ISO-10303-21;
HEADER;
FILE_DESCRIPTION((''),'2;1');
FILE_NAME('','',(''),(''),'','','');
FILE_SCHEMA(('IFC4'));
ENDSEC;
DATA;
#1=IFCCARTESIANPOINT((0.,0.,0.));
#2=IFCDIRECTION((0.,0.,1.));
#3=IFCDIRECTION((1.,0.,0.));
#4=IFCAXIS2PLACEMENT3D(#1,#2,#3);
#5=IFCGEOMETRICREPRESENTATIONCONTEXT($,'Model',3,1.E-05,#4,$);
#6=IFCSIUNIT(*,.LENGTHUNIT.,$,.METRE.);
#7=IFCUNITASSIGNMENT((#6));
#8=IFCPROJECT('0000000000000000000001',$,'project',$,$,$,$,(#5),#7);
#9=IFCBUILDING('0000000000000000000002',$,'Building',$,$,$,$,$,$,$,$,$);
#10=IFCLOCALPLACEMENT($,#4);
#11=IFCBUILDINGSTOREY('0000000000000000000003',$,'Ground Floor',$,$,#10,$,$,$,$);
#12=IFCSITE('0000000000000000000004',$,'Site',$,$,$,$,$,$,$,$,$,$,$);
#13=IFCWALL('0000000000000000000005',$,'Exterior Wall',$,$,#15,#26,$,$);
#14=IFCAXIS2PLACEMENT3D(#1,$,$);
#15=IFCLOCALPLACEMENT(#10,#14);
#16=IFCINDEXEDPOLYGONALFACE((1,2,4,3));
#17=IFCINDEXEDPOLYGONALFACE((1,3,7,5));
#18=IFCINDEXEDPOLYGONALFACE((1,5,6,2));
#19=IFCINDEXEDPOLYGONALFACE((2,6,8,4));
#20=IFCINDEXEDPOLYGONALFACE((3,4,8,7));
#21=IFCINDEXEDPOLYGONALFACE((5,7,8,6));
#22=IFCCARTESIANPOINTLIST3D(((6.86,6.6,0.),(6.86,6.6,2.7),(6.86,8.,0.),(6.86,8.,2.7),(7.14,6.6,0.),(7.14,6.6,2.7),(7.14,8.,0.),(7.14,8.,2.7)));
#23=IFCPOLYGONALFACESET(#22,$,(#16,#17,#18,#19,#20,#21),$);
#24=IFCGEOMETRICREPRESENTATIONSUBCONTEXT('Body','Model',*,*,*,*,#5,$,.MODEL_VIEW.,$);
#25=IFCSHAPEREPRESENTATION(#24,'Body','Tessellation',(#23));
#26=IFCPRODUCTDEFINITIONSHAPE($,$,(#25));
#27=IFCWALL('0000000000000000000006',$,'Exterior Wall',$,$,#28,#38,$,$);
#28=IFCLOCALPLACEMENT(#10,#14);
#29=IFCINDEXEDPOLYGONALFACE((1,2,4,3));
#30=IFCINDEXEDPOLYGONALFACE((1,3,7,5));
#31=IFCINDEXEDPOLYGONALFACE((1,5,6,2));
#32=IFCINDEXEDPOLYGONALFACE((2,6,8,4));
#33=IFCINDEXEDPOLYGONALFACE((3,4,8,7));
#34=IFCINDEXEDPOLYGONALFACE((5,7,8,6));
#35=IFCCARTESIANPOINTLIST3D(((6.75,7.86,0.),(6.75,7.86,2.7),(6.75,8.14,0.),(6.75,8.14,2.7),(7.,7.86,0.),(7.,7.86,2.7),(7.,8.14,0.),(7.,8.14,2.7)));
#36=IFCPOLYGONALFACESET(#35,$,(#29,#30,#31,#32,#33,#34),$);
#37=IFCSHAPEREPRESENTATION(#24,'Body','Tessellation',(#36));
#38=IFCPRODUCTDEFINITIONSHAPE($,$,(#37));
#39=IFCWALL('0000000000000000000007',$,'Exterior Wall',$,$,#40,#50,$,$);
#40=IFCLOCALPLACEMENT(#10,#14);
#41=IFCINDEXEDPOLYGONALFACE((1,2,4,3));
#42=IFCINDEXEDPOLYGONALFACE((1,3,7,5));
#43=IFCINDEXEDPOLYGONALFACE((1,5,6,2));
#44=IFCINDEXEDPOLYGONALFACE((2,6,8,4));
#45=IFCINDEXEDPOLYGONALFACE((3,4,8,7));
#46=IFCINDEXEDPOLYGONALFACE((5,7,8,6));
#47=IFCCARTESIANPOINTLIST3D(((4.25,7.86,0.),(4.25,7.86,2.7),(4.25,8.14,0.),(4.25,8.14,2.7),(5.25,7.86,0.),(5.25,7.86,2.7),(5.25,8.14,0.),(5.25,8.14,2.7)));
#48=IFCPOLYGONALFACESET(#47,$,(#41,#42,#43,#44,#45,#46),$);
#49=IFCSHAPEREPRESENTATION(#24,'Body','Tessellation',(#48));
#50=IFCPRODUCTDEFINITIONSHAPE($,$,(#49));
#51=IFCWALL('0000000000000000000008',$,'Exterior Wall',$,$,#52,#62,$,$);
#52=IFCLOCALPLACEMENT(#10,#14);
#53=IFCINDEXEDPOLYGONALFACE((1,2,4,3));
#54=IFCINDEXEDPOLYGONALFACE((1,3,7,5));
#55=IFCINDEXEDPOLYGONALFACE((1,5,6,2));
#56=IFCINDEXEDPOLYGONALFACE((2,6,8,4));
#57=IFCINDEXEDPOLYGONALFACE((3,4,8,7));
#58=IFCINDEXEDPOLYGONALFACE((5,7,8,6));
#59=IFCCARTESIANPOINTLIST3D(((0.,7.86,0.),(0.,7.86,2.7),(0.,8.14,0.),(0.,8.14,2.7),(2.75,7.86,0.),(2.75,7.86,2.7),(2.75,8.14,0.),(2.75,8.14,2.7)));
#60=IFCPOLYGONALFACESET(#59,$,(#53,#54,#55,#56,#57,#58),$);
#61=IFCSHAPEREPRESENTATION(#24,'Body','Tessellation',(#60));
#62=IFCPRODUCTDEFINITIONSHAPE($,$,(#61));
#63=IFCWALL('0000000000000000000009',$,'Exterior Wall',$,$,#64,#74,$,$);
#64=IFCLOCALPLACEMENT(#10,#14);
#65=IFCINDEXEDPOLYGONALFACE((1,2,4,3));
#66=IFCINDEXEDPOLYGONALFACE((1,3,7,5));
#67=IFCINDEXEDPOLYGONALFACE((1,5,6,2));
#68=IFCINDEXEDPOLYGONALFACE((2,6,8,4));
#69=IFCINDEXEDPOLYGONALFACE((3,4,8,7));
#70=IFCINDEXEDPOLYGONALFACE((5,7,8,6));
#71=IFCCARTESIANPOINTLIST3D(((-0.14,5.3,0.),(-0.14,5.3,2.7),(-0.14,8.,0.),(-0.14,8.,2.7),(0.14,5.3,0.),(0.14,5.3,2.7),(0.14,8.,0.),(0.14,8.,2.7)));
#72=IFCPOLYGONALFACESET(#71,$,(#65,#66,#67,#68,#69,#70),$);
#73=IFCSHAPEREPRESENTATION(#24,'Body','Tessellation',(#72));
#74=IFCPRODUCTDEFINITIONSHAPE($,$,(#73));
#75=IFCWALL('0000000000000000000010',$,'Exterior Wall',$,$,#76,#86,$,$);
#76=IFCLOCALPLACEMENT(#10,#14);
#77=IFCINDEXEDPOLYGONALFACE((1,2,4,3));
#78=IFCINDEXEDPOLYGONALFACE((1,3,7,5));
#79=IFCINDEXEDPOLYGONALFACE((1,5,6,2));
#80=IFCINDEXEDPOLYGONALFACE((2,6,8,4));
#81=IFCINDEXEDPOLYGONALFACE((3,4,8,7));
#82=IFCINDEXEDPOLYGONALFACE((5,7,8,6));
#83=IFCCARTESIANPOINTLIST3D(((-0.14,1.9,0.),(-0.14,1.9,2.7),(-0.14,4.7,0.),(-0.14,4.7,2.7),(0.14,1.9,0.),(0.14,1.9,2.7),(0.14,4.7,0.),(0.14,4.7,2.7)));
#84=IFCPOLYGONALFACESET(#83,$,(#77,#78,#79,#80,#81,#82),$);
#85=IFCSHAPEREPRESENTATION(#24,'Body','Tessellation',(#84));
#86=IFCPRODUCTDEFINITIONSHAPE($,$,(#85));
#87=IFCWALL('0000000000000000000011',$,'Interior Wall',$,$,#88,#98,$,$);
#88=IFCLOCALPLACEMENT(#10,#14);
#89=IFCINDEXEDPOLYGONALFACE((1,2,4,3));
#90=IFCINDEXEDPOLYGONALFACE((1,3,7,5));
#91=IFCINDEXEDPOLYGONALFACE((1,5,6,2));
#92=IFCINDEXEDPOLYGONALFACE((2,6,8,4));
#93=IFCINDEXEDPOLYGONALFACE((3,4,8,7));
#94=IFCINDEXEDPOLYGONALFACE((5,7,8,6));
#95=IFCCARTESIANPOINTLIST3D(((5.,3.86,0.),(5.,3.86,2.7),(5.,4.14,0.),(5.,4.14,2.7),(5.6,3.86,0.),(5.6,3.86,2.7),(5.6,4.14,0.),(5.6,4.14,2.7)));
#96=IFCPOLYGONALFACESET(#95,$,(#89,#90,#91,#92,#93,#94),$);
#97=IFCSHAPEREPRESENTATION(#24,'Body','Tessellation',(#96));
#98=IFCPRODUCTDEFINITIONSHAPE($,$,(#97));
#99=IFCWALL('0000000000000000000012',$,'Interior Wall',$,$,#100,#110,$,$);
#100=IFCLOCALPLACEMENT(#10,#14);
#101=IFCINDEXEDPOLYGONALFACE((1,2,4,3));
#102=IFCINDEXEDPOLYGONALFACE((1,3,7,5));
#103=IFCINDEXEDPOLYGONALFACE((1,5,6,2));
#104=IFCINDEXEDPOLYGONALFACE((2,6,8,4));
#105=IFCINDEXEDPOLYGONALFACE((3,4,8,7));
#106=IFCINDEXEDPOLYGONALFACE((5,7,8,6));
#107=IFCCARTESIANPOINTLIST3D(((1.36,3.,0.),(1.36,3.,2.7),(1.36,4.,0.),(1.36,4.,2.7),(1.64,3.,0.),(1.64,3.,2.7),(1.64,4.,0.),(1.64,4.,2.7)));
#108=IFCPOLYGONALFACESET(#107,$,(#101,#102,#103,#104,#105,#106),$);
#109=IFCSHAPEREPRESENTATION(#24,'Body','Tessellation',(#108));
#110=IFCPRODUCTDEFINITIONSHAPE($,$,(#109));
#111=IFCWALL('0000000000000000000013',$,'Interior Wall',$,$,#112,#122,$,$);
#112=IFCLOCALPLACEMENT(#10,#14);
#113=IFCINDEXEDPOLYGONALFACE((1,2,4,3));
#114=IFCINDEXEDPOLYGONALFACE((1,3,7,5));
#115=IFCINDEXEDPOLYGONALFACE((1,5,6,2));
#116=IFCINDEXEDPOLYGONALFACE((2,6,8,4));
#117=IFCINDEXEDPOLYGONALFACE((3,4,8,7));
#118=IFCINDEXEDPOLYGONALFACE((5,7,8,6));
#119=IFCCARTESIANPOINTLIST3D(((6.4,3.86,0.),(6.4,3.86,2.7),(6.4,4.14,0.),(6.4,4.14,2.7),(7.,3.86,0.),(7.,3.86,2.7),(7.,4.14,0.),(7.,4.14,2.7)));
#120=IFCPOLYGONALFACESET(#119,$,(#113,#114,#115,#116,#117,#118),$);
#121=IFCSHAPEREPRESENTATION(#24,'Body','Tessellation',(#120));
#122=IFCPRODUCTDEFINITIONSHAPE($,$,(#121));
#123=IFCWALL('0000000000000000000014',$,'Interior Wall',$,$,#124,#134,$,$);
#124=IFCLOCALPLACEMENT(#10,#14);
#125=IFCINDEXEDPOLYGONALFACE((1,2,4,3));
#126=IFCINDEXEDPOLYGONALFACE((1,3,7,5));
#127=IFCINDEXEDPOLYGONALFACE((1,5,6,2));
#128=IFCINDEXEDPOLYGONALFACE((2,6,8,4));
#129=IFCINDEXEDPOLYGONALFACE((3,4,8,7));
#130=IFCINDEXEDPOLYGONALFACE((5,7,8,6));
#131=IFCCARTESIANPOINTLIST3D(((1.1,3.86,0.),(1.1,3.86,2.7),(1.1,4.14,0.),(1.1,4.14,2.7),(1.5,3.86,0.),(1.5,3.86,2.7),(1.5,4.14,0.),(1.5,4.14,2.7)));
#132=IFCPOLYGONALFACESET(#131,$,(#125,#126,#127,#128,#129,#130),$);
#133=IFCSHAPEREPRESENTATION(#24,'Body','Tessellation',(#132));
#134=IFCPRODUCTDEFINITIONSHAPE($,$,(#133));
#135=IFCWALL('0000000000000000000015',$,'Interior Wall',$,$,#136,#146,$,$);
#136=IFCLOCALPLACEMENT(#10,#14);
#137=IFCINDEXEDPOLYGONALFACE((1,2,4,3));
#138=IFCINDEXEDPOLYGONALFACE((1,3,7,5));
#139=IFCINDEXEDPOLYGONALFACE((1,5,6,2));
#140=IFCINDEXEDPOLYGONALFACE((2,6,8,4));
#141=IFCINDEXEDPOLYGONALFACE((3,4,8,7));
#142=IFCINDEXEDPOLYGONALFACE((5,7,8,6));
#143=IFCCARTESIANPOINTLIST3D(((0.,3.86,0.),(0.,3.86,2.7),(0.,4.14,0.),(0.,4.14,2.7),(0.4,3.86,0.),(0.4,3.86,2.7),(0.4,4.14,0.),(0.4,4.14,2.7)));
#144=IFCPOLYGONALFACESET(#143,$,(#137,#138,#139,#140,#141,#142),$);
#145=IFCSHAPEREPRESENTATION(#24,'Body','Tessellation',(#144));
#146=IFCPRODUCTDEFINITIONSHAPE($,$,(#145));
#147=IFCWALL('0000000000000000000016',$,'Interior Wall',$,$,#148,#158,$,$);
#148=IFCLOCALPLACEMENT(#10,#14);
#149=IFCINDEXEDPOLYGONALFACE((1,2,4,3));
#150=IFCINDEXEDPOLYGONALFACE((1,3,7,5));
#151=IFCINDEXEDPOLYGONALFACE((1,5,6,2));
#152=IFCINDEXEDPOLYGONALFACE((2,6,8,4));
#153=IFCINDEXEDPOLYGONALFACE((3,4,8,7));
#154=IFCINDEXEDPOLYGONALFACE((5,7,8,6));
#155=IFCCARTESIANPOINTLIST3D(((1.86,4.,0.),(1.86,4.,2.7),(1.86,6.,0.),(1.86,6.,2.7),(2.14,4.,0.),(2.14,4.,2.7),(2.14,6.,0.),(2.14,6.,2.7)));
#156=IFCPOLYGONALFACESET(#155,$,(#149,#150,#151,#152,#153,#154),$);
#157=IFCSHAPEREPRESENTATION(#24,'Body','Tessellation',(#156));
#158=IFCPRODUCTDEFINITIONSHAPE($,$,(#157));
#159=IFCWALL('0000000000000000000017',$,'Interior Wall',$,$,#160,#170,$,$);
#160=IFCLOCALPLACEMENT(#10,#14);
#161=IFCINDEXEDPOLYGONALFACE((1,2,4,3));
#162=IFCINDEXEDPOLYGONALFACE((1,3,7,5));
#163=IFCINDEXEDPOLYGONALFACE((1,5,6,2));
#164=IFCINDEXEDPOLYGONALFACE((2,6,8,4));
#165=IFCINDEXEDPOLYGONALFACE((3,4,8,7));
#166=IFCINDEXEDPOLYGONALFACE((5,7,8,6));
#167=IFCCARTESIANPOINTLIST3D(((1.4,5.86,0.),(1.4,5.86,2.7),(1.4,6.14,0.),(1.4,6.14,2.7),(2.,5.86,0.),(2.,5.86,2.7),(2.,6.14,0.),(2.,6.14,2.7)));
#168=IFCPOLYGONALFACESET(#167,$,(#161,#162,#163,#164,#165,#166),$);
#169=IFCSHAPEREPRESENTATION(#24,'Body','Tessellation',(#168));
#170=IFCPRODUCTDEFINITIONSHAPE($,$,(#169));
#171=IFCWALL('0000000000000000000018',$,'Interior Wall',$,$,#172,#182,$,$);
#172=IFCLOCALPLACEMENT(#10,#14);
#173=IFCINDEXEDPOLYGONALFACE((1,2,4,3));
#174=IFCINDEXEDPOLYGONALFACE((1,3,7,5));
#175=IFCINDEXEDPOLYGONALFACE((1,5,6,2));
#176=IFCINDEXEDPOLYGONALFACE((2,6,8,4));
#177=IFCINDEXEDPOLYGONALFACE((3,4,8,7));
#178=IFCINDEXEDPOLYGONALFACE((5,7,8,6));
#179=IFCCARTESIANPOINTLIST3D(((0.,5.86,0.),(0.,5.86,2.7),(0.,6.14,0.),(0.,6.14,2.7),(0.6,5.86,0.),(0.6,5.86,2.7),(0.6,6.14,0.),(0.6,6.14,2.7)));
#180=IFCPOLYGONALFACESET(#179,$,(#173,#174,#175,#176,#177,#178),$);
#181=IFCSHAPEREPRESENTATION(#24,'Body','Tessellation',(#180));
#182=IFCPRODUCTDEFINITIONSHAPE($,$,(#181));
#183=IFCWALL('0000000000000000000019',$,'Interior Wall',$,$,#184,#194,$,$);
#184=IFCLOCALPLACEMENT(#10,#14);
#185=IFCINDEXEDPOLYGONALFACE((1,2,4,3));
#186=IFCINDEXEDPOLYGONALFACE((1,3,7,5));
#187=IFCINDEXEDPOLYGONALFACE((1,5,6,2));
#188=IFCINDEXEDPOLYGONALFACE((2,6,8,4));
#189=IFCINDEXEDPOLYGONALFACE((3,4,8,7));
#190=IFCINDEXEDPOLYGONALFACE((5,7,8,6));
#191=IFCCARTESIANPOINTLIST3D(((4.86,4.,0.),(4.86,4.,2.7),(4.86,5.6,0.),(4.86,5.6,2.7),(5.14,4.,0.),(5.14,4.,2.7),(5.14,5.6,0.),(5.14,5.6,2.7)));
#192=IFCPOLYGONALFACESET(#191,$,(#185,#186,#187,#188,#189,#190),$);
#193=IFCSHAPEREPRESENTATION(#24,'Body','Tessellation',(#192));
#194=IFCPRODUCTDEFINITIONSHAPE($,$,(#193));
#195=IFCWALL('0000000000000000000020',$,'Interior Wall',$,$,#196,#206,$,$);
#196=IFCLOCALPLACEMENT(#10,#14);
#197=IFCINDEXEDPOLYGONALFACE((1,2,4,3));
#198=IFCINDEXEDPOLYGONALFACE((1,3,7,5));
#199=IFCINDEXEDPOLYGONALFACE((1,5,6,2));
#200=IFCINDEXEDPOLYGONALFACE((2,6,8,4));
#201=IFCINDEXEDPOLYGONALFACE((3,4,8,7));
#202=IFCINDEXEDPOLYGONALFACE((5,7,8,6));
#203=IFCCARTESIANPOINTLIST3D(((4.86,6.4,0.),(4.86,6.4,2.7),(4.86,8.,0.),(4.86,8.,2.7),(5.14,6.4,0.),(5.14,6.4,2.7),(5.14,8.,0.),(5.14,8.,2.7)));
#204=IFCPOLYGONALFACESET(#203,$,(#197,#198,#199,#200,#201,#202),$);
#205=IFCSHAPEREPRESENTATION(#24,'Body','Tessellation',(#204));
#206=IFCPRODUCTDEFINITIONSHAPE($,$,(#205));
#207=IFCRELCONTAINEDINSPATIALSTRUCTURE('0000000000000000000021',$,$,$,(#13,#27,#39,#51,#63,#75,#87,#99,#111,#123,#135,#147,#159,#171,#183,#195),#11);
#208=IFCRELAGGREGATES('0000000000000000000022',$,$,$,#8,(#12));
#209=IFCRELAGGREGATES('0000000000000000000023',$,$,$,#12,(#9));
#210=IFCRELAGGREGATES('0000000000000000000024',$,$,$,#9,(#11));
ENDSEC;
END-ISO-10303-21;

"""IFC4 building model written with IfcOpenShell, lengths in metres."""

from ifc_helpers import new_model, si_unit, frame, origin_with_axes, place, context, subcontext, project, spatial, indexed_curve, outline, extrude, element, save


model = new_model("IFC4")

# Units and contexts
model_context = context("Model", 3, precision=1e-05, world=origin_with_axes())
body_context = subcontext(model_context, "Body", "Model", "MODEL_VIEW")
ifc_project = project(units=[si_unit("LENGTHUNIT", "METRE")], contexts=[model_context])

# Site, building, storey
site = spatial("IfcSite", under=ifc_project, Name="Site")
building = spatial("IfcBuilding", under=site, Name="Building")
storey_placement = place(None, origin_with_axes())
storey = spatial("IfcBuildingStorey", under=building, at=storey_placement, Name="Ground Floor")

# Walls
wall_1_placement = place(storey_placement, frame((7.0, 6.6, 0.0), z_axis=(0.0, 0.0, 1.0), x_axis=(0.0, 1.0, 0.0)))
element("IfcWall", 1, at=wall_1_placement, inside=storey, Name="Exterior Wall", context=body_context, shape_type="SweptSolid", body=[
    extrude(outline(indexed_curve([(0.0, 0.0), (0.0, 0.28), (1.4, 0.28), (1.4, 0.0), (0.0, 0.0)], self_intersect=False)), frame((0.0, -0.14, 0.0), z_axis=(0.0, 0.0, 1.0), x_axis=(1.0, 0.0, 0.0)), (0.0, 0.0, 1.0), 2.7),
])
wall_2_placement = place(storey_placement, frame((7.0, 8.0, 0.0), z_axis=(0.0, 0.0, 1.0), x_axis=(-1.0, 0.0, 0.0)))
element("IfcWall", 2, at=wall_2_placement, inside=storey, Name="Exterior Wall", context=body_context, shape_type="SweptSolid", body=[
    extrude(outline(indexed_curve([(0.0, 0.0), (0.0, 0.28), (0.25, 0.28), (0.25, 0.0), (0.0, 0.0)], self_intersect=False)), frame((0.0, -0.14, 0.0), z_axis=(0.0, 0.0, 1.0), x_axis=(1.0, 0.0, 0.0)), (0.0, 0.0, 1.0), 2.7),
])
wall_3_placement = place(storey_placement, frame((5.25, 8.0, 0.0), z_axis=(0.0, 0.0, 1.0), x_axis=(-1.0, 0.0, 0.0)))
element("IfcWall", 3, at=wall_3_placement, inside=storey, Name="Exterior Wall", context=body_context, shape_type="SweptSolid", body=[
    extrude(outline(indexed_curve([(0.0, 0.0), (0.0, 0.28), (1.0, 0.28), (1.0, 0.0), (0.0, 0.0)], self_intersect=False)), frame((0.0, -0.14, 0.0), z_axis=(0.0, 0.0, 1.0), x_axis=(1.0, 0.0, 0.0)), (0.0, 0.0, 1.0), 2.7),
])
wall_4_placement = place(storey_placement, frame((2.75, 8.0, 0.0), z_axis=(0.0, 0.0, 1.0), x_axis=(-1.0, 0.0, 0.0)))
element("IfcWall", 4, at=wall_4_placement, inside=storey, Name="Exterior Wall", context=body_context, shape_type="SweptSolid", body=[
    extrude(outline(indexed_curve([(0.0, 0.0), (0.0, 0.28), (2.75, 0.28), (2.75, 0.0), (0.0, 0.0)], self_intersect=False)), frame((0.0, -0.14, 0.0), z_axis=(0.0, 0.0, 1.0), x_axis=(1.0, 0.0, 0.0)), (0.0, 0.0, 1.0), 2.7),
])
wall_5_placement = place(storey_placement, frame((0.0, 8.0, 0.0), z_axis=(0.0, 0.0, 1.0), x_axis=(0.0, -1.0, 0.0)))
element("IfcWall", 5, at=wall_5_placement, inside=storey, Name="Exterior Wall", context=body_context, shape_type="SweptSolid", body=[
    extrude(outline(indexed_curve([(0.0, 0.0), (0.0, 0.28), (2.7, 0.28), (2.7, 0.0), (0.0, 0.0)], self_intersect=False)), frame((0.0, -0.14, 0.0), z_axis=(0.0, 0.0, 1.0), x_axis=(1.0, 0.0, 0.0)), (0.0, 0.0, 1.0), 2.7),
])
wall_6_placement = place(storey_placement, frame((0.0, 4.7, 0.0), z_axis=(0.0, 0.0, 1.0), x_axis=(0.0, -1.0, 0.0)))
element("IfcWall", 6, at=wall_6_placement, inside=storey, Name="Exterior Wall", context=body_context, shape_type="SweptSolid", body=[
    extrude(outline(indexed_curve([(0.0, 0.0), (0.0, 0.28), (2.8, 0.28), (2.8, 0.0), (0.0, 0.0)], self_intersect=False)), frame((0.0, -0.14, 0.0), z_axis=(0.0, 0.0, 1.0), x_axis=(1.0, 0.0, 0.0)), (0.0, 0.0, 1.0), 2.7),
])
wall_7_placement = place(storey_placement, frame((5.6, 4.0, 0.0), z_axis=(0.0, 0.0, 1.0), x_axis=(-1.0, 0.0, 0.0)))
element("IfcWall", 7, at=wall_7_placement, inside=storey, Name="Interior Wall", context=body_context, shape_type="SweptSolid", body=[
    extrude(outline(indexed_curve([(0.0, 0.0), (0.0, 0.28), (0.6, 0.28), (0.6, 0.0), (0.0, 0.0)], self_intersect=False)), frame((0.0, -0.14, 0.0), z_axis=(0.0, 0.0, 1.0), x_axis=(1.0, 0.0, 0.0)), (0.0, 0.0, 1.0), 2.7),
])
wall_8_placement = place(storey_placement, frame((1.5, 4.0, 0.0), z_axis=(0.0, 0.0, 1.0), x_axis=(0.0, -1.0, 0.0)))
element("IfcWall", 8, at=wall_8_placement, inside=storey, Name="Interior Wall", context=body_context, shape_type="SweptSolid", body=[
    extrude(outline(indexed_curve([(0.0, 0.0), (0.0, 0.28), (1.0, 0.28), (1.0, 0.0), (0.0, 0.0)], self_intersect=False)), frame((0.0, -0.14, 0.0), z_axis=(0.0, 0.0, 1.0), x_axis=(1.0, 0.0, 0.0)), (0.0, 0.0, 1.0), 2.7),
])
wall_9_placement = place(storey_placement, frame((7.0, 4.0, 0.0), z_axis=(0.0, 0.0, 1.0), x_axis=(-1.0, 0.0, 0.0)))
element("IfcWall", 9, at=wall_9_placement, inside=storey, Name="Interior Wall", context=body_context, shape_type="SweptSolid", body=[
    extrude(outline(indexed_curve([(0.0, 0.0), (0.0, 0.28), (0.6, 0.28), (0.6, 0.0), (0.0, 0.0)], self_intersect=False)), frame((0.0, -0.14, 0.0), z_axis=(0.0, 0.0, 1.0), x_axis=(1.0, 0.0, 0.0)), (0.0, 0.0, 1.0), 2.7),
])
for number, where, z_axis, x_axis, name in (
    (10, (1.5, 4.0, 0.0), (0.0, 0.0, 1.0), (-1.0, 0.0, 0.0), "Interior Wall"),
    (11, (0.4, 4.0, 0.0), (0.0, 0.0, 1.0), (-1.0, 0.0, 0.0), "Interior Wall"),
):
    element("IfcWall", number, at=place(storey_placement, frame(where, z_axis=z_axis, x_axis=x_axis)), inside=storey, Name=name, context=body_context, shape_type="SweptSolid", body=[
        extrude(outline(indexed_curve([(0.0, 0.0), (0.0, 0.28), (0.4, 0.28), (0.4, 0.0), (0.0, 0.0)], self_intersect=False)), frame((0.0, -0.14, 0.0), z_axis=(0.0, 0.0, 1.0), x_axis=(1.0, 0.0, 0.0)), (0.0, 0.0, 1.0), 2.7),
    ])
wall_10_placement = place(storey_placement, frame((2.0, 4.0, 0.0), z_axis=(0.0, 0.0, 1.0), x_axis=(0.0, 1.0, 0.0)))
element("IfcWall", 12, at=wall_10_placement, inside=storey, Name="Interior Wall", context=body_context, shape_type="SweptSolid", body=[
    extrude(outline(indexed_curve([(0.0, 0.0), (0.0, 0.28), (2.0, 0.28), (2.0, 0.0), (0.0, 0.0)], self_intersect=False)), frame((0.0, -0.14, 0.0), z_axis=(0.0, 0.0, 1.0), x_axis=(1.0, 0.0, 0.0)), (0.0, 0.0, 1.0), 2.7),
])
for number, where, z_axis, x_axis, name in (
    (13, (2.0, 6.0, 0.0), (0.0, 0.0, 1.0), (-1.0, 0.0, 0.0), "Interior Wall"),
    (14, (0.6, 6.0, 0.0), (0.0, 0.0, 1.0), (-1.0, 0.0, 0.0), "Interior Wall"),
):
    element("IfcWall", number, at=place(storey_placement, frame(where, z_axis=z_axis, x_axis=x_axis)), inside=storey, Name=name, context=body_context, shape_type="SweptSolid", body=[
        extrude(outline(indexed_curve([(0.0, 0.0), (0.0, 0.28), (0.6, 0.28), (0.6, 0.0), (0.0, 0.0)], self_intersect=False)), frame((0.0, -0.14, 0.0), z_axis=(0.0, 0.0, 1.0), x_axis=(1.0, 0.0, 0.0)), (0.0, 0.0, 1.0), 2.7),
    ])
for number, where, z_axis, x_axis, name in (
    (15, (5.0, 4.0, 0.0), (0.0, 0.0, 1.0), (0.0, 1.0, 0.0), "Interior Wall"),
    (16, (5.0, 6.4, 0.0), (0.0, 0.0, 1.0), (0.0, 1.0, 0.0), "Interior Wall"),
):
    element("IfcWall", number, at=place(storey_placement, frame(where, z_axis=z_axis, x_axis=x_axis)), inside=storey, Name=name, context=body_context, shape_type="SweptSolid", body=[
        extrude(outline(indexed_curve([(0.0, 0.0), (0.0, 0.28), (1.6, 0.28), (1.6, 0.0), (0.0, 0.0)], self_intersect=False)), frame((0.0, -0.14, 0.0), z_axis=(0.0, 0.0, 1.0), x_axis=(1.0, 0.0, 0.0)), (0.0, 0.0, 1.0), 2.7),
    ])

save(model, "model.ifc")
